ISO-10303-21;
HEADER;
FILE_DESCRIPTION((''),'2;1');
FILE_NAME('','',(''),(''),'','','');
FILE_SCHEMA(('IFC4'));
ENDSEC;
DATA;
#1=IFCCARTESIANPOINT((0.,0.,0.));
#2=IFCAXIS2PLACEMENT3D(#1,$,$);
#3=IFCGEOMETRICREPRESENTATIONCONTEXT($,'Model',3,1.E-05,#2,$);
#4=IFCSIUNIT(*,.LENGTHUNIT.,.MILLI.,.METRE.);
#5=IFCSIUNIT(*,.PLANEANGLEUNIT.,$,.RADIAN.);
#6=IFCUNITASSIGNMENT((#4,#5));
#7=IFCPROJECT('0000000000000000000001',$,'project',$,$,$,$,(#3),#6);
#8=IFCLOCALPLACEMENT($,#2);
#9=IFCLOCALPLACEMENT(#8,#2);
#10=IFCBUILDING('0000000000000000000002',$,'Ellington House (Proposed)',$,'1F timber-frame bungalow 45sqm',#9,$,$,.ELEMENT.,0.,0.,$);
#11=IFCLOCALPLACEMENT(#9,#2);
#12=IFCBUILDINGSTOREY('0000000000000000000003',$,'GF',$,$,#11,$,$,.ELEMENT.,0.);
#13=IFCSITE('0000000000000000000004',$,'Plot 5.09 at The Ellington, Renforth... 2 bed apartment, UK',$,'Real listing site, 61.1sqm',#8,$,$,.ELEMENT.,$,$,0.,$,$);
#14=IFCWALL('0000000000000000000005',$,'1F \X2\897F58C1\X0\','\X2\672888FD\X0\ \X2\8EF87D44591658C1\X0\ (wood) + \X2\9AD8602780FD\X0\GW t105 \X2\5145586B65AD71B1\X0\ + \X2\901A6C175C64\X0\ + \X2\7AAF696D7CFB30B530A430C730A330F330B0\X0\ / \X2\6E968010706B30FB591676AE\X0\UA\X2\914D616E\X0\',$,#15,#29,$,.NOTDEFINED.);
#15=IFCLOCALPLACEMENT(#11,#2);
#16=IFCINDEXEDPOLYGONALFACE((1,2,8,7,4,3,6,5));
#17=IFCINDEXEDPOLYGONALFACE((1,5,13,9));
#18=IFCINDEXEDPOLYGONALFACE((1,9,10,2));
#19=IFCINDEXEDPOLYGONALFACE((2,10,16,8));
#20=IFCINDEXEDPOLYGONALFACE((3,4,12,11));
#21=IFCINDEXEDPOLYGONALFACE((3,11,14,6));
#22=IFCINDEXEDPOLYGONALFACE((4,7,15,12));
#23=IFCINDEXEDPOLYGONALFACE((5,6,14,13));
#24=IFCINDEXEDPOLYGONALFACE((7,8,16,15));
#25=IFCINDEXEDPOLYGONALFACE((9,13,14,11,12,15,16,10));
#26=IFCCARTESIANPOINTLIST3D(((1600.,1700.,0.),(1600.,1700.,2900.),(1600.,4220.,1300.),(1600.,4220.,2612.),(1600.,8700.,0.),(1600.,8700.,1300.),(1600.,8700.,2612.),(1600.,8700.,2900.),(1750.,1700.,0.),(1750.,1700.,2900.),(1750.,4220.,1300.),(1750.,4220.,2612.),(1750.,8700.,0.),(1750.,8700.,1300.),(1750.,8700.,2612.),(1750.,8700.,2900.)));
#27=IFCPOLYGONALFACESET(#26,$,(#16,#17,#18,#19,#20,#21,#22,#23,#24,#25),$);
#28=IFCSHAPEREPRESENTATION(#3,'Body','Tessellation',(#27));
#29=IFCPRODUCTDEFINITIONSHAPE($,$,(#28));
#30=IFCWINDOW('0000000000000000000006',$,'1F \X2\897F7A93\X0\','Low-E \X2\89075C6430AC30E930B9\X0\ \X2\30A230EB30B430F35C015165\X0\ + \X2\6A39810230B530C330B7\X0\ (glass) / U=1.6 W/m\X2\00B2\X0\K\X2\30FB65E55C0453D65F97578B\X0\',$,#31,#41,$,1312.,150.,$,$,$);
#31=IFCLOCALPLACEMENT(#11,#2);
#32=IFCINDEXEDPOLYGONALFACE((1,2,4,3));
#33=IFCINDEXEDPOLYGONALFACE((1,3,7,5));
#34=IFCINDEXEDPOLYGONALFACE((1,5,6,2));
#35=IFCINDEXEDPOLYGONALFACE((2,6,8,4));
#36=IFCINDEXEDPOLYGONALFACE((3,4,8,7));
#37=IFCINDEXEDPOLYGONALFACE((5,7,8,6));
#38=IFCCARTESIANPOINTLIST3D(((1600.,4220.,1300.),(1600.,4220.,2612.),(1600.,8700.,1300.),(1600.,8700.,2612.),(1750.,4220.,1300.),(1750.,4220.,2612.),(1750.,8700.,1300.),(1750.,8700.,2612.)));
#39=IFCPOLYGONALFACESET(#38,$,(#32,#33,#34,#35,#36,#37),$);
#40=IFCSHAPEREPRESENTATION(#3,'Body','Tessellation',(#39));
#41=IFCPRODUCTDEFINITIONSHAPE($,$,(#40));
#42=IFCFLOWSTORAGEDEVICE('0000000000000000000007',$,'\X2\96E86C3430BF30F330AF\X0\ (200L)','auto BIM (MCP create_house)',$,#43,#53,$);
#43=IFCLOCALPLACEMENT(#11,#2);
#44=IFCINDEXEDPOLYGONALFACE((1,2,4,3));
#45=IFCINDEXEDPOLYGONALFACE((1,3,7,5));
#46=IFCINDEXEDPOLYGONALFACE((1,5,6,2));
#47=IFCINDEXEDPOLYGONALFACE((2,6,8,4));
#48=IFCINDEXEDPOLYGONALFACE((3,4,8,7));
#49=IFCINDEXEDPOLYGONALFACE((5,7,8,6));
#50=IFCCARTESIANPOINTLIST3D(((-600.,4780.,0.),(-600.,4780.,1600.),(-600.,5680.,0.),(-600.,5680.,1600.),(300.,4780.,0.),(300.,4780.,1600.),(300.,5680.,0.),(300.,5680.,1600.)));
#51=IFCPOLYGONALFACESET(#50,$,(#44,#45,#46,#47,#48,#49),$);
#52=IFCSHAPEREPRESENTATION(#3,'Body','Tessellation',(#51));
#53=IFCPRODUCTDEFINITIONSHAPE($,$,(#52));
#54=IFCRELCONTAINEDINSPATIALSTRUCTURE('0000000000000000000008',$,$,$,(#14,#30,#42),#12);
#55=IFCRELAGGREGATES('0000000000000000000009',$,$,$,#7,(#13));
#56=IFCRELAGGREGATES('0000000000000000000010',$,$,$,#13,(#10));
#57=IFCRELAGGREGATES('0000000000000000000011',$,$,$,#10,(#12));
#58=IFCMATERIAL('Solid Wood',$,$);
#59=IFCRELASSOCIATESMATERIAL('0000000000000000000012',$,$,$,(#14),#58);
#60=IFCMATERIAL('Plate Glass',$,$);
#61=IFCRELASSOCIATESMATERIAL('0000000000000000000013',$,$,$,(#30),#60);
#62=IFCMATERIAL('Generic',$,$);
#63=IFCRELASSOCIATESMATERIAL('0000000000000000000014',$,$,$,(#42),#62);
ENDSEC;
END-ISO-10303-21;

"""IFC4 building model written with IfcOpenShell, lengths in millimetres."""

from ifc_helpers import new_model, si_unit, frame, frame_2d, origin, place, context, project, spatial, rectangle, extrude, material, element, fill, save


model = new_model("IFC4")

# Units and contexts
model_context = context("Model", 3, precision=1e-05, world=origin())
ifc_project = project(units=[si_unit("LENGTHUNIT", "METRE", prefix="MILLI"), si_unit("PLANEANGLEUNIT", "RADIAN")], contexts=[model_context])

# Site, building, storey
site_placement = place(None, origin())
site = spatial("IfcSite", under=ifc_project, at=site_placement, Name="Plot 5.09 at The Ellington, Renforth... 2 bed apartment, UK", ObjectType="Real listing site, 61.1sqm", CompositionType="ELEMENT", RefElevation=0.0)
building_placement = place(site_placement, origin())
building = spatial("IfcBuilding", under=site, at=building_placement, Name="Ellington House (Proposed)", ObjectType="1F timber-frame bungalow 45sqm", CompositionType="ELEMENT", ElevationOfRefHeight=0.0, ElevationOfTerrain=0.0)
storey_placement = place(building_placement, origin())
storey = spatial("IfcBuildingStorey", under=building, at=storey_placement, Name="GF", CompositionType="ELEMENT", Elevation=0.0)

# Shared definitions
ifc_material_1 = material(Name="Solid Wood")

# Shared definitions
ifc_material_2 = material(Name="Plate Glass")
ifc_material_3 = material(Name="Generic")

# Wall, opening, window
wall_1_placement = place(storey_placement, frame((800.0, 850.0, 0.0)))
wall_1 = element("IfcWall", 1, at=wall_1_placement, inside=storey, material=ifc_material_1, Name="1F 西壁", Description="木製 軸組外壁 (wood) + 高性能GW t105 充填断熱 + 通気層 + 窯業系サイディング / 準耐火・外皮UA配慮", PredefinedType="NOTDEFINED", context=model_context, shape_type="SweptSolid", body=[
    extrude(rectangle(XDim=150.0, YDim=7000.0, at=frame_2d((75.0, 3500.0))), frame((800.0, 850.0, 0.0)), (0.0, 0.0, 1.0), 2900.0),
])
opening_1_placement = place(storey_placement, frame((800.0, 2110.0, 650.0)))
opening_1 = element("IfcOpeningElement", 2, at=opening_1_placement, cuts=wall_1, PredefinedType="NOTDEFINED", context=model_context, shape_type="SweptSolid", body=[
    extrude(rectangle(XDim=150.0, YDim=4480.0, at=frame_2d((75.0, 2240.0))), frame((800.0, 2110.0, 650.0)), (0.0, 0.0, 1.0), 1312.0),
])
window_1_placement = place(storey_placement, frame((800.0, 2110.0, 650.0)))
window_1 = element("IfcWindow", 3, at=window_1_placement, inside=storey, material=ifc_material_2, Name="1F 西窓", Description="Low-E 複層ガラス アルゴン封入 + 樹脂サッシ (glass) / U=1.6 W/m²K・日射取得型", OverallHeight=1312.0, OverallWidth=150.0, context=model_context, shape_type="SweptSolid", body=[
    extrude(rectangle(XDim=150.0, YDim=4480.0, at=frame_2d((75.0, 2240.0))), frame((800.0, 2110.0, 650.0)), (0.0, 0.0, 1.0), 1312.0),
])
fill(opening_1, window_1)

# Flow storage device
flow_storage_device_placement = place(storey_placement, frame((-300.0, 2390.0, 0.0)))
element("IfcFlowStorageDevice", 4, at=flow_storage_device_placement, inside=storey, material=ifc_material_3, Name="雨水タンク (200L)", Description="auto BIM (MCP create_house)", context=model_context, shape_type="SweptSolid", body=[
    extrude(rectangle(XDim=900.0, YDim=900.0, at=frame_2d((450.0, 450.0))), frame((-300.0, 2390.0, 0.0)), (0.0, 0.0, 1.0), 1600.0),
])

save(model, "model.ifc")
